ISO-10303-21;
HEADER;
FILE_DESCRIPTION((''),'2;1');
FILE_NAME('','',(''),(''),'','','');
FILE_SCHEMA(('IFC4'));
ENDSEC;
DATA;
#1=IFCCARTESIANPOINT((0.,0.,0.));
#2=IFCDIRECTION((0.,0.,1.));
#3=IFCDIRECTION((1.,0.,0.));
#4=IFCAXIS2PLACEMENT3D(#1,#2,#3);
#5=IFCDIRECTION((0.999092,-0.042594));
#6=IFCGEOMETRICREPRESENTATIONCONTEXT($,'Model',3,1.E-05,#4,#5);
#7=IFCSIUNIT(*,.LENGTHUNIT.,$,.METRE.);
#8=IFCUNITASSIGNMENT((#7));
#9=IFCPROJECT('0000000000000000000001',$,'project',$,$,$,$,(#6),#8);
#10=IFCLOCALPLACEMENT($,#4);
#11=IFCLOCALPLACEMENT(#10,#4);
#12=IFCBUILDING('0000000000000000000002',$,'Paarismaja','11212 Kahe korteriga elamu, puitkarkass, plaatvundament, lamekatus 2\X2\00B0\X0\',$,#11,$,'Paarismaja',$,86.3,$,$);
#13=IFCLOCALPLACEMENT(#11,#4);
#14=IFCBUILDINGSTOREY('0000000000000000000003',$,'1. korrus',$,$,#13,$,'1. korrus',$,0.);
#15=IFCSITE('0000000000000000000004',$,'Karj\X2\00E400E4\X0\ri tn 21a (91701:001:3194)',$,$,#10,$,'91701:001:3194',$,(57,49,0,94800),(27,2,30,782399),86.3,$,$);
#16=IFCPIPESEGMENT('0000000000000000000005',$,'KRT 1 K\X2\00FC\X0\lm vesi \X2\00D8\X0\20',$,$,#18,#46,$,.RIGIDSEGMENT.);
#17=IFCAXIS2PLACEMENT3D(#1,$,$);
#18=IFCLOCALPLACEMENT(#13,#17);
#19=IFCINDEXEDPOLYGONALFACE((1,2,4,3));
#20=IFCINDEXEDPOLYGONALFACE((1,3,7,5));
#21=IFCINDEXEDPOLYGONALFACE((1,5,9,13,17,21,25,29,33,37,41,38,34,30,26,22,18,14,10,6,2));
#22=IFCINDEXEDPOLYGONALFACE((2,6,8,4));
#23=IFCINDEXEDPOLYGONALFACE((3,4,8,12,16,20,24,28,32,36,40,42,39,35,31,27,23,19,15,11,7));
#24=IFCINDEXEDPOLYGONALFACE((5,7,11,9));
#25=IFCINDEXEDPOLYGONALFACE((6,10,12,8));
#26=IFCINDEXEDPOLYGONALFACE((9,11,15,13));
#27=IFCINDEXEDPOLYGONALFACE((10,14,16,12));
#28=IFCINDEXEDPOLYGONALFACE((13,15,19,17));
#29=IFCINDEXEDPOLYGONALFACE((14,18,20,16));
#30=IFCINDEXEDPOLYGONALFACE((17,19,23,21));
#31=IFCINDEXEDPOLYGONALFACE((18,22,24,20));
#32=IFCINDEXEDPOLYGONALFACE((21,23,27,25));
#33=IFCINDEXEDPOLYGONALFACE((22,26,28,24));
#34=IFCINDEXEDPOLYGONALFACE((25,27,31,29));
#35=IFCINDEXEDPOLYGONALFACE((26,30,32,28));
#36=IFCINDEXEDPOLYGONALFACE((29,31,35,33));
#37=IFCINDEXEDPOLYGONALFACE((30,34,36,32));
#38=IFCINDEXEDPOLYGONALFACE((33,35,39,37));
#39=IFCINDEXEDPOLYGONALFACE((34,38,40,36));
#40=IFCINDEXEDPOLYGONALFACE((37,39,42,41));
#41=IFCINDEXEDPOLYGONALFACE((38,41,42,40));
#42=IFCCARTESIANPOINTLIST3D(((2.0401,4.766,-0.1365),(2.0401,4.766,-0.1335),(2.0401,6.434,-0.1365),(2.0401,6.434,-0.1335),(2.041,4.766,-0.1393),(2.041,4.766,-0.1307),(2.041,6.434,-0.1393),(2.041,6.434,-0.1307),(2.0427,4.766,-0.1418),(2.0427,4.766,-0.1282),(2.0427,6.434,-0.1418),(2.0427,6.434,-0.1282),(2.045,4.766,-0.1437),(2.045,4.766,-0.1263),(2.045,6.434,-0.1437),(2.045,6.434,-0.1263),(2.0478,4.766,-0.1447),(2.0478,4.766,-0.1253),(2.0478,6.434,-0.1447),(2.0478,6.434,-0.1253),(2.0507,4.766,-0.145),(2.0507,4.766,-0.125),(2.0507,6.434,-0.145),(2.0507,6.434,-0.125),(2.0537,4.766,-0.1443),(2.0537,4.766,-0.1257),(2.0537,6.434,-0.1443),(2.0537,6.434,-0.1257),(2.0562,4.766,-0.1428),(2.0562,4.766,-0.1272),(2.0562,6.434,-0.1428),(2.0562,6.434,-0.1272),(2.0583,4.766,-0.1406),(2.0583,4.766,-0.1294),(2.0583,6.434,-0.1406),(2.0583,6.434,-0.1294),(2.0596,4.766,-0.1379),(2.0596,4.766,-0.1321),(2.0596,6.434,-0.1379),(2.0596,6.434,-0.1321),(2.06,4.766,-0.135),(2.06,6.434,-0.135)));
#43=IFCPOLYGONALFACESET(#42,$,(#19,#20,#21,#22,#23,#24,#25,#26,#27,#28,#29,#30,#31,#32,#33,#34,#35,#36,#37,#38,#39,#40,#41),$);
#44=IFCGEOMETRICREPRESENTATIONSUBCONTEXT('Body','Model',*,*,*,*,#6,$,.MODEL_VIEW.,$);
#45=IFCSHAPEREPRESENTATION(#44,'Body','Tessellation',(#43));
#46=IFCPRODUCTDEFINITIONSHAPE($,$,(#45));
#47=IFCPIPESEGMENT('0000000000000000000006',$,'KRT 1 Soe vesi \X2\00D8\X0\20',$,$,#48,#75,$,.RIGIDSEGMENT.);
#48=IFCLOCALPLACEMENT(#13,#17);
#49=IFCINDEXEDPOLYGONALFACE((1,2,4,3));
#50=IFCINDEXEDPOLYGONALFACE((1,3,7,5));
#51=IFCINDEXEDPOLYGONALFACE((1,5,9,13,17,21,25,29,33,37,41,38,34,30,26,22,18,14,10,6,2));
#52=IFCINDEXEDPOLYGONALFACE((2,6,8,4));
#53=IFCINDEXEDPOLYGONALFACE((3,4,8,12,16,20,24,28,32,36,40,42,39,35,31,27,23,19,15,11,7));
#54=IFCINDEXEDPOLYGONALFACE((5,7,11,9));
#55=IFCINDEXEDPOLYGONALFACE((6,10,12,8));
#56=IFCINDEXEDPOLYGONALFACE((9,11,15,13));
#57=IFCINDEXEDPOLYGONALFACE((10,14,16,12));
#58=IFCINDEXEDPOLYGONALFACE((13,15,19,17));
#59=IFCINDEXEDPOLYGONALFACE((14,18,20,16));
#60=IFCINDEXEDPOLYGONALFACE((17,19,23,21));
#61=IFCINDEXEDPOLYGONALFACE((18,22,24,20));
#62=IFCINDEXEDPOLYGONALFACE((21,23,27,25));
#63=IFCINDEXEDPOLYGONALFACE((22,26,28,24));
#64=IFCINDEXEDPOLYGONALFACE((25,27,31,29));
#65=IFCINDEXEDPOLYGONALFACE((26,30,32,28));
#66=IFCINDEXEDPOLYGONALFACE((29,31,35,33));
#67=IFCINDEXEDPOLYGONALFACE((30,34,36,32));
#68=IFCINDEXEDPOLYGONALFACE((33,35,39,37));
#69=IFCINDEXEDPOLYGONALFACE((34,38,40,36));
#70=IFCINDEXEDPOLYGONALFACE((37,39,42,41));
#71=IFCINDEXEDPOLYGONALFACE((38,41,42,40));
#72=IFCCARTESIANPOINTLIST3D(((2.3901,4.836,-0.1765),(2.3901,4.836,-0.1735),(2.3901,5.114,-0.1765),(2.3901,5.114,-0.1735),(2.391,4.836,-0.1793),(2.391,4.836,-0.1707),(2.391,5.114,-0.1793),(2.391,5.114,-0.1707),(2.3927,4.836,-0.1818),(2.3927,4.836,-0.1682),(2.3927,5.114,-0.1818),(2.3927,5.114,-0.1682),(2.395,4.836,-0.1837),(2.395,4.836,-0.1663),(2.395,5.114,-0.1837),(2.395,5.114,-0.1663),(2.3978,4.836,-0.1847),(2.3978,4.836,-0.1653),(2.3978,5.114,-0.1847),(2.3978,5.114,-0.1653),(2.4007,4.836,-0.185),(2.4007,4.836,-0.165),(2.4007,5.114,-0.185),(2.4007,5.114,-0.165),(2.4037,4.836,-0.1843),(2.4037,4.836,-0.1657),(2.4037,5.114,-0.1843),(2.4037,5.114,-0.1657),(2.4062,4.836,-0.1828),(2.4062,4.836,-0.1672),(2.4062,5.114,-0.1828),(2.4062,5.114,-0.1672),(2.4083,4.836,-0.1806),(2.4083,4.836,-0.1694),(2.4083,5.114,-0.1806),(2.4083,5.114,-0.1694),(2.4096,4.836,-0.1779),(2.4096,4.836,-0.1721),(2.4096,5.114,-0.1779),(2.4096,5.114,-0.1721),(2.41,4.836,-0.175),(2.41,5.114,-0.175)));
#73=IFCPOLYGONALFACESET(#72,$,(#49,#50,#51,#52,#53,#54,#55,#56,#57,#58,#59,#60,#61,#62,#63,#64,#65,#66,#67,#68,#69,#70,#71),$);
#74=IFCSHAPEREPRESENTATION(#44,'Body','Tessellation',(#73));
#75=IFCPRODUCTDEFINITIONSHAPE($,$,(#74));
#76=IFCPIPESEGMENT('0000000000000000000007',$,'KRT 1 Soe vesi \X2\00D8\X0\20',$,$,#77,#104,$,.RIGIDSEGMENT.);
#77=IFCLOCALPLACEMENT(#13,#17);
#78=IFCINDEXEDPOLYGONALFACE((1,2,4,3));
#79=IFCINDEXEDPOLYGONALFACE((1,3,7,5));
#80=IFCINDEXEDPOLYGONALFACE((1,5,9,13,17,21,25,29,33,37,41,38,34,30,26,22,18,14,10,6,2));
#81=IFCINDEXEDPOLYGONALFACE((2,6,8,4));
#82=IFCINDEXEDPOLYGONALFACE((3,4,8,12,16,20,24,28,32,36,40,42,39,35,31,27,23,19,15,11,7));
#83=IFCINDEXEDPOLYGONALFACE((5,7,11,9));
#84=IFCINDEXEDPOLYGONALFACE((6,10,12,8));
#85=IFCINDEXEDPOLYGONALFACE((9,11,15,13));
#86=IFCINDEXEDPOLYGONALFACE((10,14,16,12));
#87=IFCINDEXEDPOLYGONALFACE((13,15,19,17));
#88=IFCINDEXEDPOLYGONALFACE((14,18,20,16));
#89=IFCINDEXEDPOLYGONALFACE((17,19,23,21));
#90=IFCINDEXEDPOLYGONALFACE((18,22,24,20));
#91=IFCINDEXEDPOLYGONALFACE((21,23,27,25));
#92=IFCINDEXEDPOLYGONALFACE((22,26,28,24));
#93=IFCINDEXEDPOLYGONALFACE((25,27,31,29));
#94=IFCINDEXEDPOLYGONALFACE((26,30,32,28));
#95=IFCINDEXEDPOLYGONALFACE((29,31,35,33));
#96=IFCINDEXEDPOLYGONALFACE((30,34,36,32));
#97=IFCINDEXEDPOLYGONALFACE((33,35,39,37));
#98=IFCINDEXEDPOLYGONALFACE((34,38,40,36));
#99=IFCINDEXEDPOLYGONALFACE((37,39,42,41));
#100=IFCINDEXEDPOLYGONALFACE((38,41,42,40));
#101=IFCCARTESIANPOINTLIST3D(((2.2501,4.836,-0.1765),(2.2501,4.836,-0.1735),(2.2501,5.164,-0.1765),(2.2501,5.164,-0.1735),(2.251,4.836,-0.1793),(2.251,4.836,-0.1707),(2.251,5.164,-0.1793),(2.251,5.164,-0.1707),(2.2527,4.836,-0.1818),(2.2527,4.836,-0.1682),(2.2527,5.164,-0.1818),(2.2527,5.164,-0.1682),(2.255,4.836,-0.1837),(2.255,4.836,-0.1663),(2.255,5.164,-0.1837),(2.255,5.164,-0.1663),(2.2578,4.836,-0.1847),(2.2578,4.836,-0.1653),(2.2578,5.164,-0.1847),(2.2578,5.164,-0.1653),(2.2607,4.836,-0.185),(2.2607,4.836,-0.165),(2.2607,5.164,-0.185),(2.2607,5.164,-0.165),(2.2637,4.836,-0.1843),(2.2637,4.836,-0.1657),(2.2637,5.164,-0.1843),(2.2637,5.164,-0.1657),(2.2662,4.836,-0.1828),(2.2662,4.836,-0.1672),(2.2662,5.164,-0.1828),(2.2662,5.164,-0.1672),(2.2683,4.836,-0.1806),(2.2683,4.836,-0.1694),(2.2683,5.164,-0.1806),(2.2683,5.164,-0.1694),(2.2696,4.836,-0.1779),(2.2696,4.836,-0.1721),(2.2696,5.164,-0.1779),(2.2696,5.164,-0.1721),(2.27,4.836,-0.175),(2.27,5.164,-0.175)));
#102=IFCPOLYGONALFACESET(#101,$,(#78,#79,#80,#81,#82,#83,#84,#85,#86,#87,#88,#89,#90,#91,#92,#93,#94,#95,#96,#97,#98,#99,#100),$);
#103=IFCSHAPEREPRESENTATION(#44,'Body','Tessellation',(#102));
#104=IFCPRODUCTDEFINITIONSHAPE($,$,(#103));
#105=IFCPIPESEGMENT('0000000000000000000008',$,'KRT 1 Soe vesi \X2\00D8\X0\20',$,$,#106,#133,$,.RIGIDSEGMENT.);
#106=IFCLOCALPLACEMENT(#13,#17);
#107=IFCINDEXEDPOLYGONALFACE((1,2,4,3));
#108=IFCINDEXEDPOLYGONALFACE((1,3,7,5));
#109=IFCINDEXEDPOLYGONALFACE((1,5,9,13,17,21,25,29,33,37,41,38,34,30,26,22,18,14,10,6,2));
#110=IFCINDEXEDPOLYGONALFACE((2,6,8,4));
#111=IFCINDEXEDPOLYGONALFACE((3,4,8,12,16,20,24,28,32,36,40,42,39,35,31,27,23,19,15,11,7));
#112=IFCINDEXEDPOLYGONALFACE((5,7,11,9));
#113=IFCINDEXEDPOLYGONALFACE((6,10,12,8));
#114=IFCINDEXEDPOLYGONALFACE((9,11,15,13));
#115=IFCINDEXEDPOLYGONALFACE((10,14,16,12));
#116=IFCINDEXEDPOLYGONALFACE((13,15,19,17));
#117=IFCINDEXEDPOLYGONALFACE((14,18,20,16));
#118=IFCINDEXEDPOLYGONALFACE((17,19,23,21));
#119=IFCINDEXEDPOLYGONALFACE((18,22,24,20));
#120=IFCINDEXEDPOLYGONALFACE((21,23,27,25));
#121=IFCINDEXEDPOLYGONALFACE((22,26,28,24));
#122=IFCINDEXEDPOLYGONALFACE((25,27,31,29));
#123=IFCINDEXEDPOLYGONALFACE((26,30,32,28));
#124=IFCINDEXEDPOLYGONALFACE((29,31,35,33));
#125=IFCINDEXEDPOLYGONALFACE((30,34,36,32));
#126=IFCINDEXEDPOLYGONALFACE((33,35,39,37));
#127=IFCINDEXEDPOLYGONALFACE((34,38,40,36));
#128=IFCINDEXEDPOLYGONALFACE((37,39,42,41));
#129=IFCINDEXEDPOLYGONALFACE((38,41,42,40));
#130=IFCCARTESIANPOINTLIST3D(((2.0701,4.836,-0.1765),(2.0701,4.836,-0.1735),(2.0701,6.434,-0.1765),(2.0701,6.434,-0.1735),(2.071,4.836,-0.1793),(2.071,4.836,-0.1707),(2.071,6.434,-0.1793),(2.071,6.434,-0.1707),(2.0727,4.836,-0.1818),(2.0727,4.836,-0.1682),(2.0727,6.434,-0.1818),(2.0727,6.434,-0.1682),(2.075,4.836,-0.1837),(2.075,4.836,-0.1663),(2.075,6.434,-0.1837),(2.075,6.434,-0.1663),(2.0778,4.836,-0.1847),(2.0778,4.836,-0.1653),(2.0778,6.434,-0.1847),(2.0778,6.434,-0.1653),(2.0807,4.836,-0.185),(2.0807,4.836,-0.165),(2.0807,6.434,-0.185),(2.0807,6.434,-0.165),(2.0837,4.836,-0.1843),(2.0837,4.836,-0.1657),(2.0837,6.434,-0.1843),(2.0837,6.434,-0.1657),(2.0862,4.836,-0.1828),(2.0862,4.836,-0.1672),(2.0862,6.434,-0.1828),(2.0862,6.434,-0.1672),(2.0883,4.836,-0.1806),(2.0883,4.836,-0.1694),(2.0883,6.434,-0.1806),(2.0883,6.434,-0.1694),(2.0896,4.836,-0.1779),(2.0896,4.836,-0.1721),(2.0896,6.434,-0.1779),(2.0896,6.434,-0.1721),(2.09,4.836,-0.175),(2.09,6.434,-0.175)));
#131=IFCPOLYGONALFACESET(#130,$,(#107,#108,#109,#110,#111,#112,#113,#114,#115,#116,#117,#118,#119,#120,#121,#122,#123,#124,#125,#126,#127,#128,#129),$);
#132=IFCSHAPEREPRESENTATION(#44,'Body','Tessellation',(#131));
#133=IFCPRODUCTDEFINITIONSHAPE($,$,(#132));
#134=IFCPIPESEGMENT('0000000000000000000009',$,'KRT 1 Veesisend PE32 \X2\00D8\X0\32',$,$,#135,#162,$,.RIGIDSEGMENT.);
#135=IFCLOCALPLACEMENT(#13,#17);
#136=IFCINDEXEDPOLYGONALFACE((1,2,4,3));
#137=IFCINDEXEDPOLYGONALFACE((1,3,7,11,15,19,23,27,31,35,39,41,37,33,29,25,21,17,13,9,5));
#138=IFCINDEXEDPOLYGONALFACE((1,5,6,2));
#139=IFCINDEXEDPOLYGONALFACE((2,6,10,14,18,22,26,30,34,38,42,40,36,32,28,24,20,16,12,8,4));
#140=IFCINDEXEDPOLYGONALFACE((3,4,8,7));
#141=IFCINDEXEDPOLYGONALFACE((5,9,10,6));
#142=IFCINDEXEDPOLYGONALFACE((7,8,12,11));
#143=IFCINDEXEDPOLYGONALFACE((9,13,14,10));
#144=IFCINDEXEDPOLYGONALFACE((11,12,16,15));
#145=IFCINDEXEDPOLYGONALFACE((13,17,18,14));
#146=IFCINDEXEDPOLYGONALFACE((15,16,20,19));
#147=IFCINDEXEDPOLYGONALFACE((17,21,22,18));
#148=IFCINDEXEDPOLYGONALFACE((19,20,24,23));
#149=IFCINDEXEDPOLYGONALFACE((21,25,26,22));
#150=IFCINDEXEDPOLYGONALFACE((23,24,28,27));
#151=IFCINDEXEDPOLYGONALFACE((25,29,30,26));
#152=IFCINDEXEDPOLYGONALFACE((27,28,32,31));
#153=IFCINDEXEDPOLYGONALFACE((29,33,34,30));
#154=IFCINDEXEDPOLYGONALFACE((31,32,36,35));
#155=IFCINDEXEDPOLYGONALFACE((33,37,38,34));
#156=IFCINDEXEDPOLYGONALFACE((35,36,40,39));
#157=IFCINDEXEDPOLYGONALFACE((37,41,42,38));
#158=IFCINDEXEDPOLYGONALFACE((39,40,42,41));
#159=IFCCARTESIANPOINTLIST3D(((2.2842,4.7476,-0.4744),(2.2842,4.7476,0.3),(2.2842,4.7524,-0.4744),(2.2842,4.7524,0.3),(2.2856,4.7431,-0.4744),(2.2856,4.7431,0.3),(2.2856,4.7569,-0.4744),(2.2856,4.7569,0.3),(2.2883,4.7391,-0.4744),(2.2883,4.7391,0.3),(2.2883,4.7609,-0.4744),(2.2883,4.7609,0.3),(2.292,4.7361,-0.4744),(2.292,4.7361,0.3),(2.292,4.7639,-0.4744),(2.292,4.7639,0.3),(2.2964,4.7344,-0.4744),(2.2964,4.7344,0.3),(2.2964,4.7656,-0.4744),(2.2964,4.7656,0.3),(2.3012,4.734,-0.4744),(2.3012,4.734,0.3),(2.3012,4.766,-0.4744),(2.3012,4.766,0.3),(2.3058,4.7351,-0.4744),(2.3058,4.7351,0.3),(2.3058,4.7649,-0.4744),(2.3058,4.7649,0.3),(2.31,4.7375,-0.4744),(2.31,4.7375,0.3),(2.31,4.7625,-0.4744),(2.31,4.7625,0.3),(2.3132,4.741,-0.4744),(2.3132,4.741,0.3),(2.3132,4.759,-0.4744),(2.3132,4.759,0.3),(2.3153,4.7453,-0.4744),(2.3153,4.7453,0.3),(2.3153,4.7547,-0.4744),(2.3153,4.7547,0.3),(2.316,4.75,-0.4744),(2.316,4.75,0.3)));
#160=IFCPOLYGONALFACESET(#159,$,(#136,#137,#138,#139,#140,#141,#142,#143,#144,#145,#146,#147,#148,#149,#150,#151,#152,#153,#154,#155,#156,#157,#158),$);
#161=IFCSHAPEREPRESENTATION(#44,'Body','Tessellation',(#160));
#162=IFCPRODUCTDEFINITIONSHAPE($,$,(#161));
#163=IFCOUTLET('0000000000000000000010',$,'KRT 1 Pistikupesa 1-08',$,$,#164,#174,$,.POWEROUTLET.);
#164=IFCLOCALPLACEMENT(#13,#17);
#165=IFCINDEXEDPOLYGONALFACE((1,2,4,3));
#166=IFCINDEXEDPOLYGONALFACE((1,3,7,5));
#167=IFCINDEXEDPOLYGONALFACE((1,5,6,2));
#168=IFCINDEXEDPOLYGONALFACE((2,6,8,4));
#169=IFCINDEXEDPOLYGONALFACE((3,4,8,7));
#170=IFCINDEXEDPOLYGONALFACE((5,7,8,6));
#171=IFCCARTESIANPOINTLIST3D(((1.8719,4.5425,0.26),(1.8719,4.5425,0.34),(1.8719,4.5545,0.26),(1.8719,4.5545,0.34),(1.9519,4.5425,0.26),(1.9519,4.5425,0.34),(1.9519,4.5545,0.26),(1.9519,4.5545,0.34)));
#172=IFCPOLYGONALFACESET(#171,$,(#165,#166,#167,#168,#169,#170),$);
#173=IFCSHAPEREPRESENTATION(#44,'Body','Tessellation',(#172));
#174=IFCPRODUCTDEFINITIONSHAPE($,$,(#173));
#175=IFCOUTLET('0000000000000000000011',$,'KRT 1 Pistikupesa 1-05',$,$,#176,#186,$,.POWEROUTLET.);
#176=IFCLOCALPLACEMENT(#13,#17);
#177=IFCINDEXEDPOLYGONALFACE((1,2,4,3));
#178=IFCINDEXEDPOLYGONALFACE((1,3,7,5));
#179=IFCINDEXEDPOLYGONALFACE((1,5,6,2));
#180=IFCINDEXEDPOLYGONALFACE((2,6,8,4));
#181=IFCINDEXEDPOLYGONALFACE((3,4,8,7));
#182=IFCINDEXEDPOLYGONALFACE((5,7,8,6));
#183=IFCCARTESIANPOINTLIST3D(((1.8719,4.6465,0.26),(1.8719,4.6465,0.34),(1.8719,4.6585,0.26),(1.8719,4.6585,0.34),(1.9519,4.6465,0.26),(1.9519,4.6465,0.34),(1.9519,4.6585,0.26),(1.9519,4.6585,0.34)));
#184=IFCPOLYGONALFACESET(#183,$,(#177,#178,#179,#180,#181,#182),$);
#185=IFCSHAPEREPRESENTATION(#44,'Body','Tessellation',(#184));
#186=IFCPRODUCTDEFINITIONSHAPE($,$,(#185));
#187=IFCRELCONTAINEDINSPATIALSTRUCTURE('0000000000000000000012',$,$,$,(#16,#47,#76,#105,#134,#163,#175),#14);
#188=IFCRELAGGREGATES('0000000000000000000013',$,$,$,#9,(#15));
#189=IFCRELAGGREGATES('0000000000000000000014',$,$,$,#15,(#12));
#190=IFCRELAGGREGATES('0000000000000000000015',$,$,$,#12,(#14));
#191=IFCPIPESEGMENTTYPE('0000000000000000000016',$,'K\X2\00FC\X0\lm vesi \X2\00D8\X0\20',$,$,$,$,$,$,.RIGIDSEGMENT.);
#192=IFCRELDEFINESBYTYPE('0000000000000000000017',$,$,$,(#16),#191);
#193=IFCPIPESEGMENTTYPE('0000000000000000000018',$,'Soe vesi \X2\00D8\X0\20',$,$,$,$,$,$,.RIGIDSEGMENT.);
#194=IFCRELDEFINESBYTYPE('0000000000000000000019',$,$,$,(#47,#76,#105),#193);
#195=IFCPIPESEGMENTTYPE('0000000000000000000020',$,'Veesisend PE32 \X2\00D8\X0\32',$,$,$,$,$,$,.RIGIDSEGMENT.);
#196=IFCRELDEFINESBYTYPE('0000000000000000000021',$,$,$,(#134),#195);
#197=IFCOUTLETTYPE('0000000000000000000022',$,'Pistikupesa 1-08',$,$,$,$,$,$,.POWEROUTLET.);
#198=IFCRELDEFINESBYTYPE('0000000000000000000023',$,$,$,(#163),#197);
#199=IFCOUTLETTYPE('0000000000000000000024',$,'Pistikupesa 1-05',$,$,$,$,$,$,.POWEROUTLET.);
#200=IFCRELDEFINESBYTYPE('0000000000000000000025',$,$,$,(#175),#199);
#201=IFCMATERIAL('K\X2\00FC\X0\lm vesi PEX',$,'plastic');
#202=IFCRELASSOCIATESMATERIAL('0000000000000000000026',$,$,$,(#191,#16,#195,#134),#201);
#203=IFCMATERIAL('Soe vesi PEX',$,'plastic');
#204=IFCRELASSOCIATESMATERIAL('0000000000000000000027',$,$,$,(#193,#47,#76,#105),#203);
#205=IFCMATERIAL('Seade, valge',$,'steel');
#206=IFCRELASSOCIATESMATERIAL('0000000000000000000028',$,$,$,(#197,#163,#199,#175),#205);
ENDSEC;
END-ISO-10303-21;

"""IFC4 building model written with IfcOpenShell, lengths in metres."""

from ifc_helpers import new_model, si_unit, direction, frame, origin_with_axes, place, context, subcontext, project, spatial, indexed_curve, circle, outline, extrude, material, type_object, element, save


model = new_model("IFC4")

# Units and contexts
model_context = context("Model", 3, precision=1e-05, world=origin_with_axes(), true_north=direction((0.999092, -0.042594)))
body_context = subcontext(model_context, "Body", "Model", "MODEL_VIEW")
ifc_project = project(units=[si_unit("LENGTHUNIT", "METRE")], contexts=[model_context])

# Site, building, storey
site_placement = place(None, origin_with_axes())
site = spatial("IfcSite", under=ifc_project, at=site_placement, Name="Karjääri tn 21a (91701:001:3194)", LongName="91701:001:3194", RefLatitude=(57, 49, 0, 94800), RefLongitude=(27, 2, 30, 782399), RefElevation=86.3)
building_placement = place(site_placement, origin_with_axes())
building = spatial("IfcBuilding", under=site, at=building_placement, Name="Paarismaja", Description="11212 Kahe korteriga elamu, puitkarkass, plaatvundament, lamekatus 2°", LongName="Paarismaja", ElevationOfRefHeight=86.3)
storey_placement = place(building_placement, origin_with_axes())
storey = spatial("IfcBuildingStorey", under=building, at=storey_placement, Name="1. korrus", LongName="1. korrus", Elevation=0.0)

# Shared definitions
ifc_material_1 = material(Name="Seade, valge", Category="steel")

# Shared definitions
ifc_material_2 = material(Name="Külm vesi PEX", Category="plastic")
ifc_material_3 = material(Name="Soe vesi PEX", Category="plastic")

# Pipe segments
pipe_segment_type_1 = type_object("IfcPipeSegmentType", Name="Külm vesi Ø20", PredefinedType="RIGIDSEGMENT", material=ifc_material_2)
pipe_segment_1_placement = place(storey_placement, frame((2.05, 4.766, -0.135), z_axis=(0.0, 1.0, 0.0), x_axis=(1.0, 0.0, 0.0)))
element("IfcPipeSegment", 1, at=pipe_segment_1_placement, inside=storey, type_object=pipe_segment_type_1, material=ifc_material_2, Name="KRT 1 Külm vesi Ø20", PredefinedType="RIGIDSEGMENT", context=body_context, shape_type="SweptSolid", body=[
    extrude(circle(Radius=0.01), origin_with_axes(), (0.0, 0.0, 1.0), 1.668),
])
pipe_segment_type_2 = type_object("IfcPipeSegmentType", Name="Soe vesi Ø20", PredefinedType="RIGIDSEGMENT", material=ifc_material_3)
pipe_segment_2_placement = place(storey_placement, frame((2.4, 4.836, -0.175), z_axis=(0.0, 1.0, 0.0), x_axis=(1.0, 0.0, 0.0)))
element("IfcPipeSegment", 2, at=pipe_segment_2_placement, inside=storey, type_object=pipe_segment_type_2, material=ifc_material_3, Name="KRT 1 Soe vesi Ø20", PredefinedType="RIGIDSEGMENT", context=body_context, shape_type="SweptSolid", body=[
    extrude(circle(Radius=0.01), origin_with_axes(), (0.0, 0.0, 1.0), 0.278),
])
pipe_segment_3_placement = place(storey_placement, frame((2.26, 4.836, -0.175), z_axis=(0.0, 1.0, 0.0), x_axis=(1.0, 0.0, 0.0)))
element("IfcPipeSegment", 3, at=pipe_segment_3_placement, inside=storey, type_object=pipe_segment_type_2, material=ifc_material_3, Name="KRT 1 Soe vesi Ø20", PredefinedType="RIGIDSEGMENT", context=body_context, shape_type="SweptSolid", body=[
    extrude(circle(Radius=0.01), origin_with_axes(), (0.0, 0.0, 1.0), 0.328),
])
pipe_segment_4_placement = place(storey_placement, frame((2.08, 4.836, -0.175), z_axis=(0.0, 1.0, 0.0), x_axis=(1.0, 0.0, 0.0)))
element("IfcPipeSegment", 4, at=pipe_segment_4_placement, inside=storey, type_object=pipe_segment_type_2, material=ifc_material_3, Name="KRT 1 Soe vesi Ø20", PredefinedType="RIGIDSEGMENT", context=body_context, shape_type="SweptSolid", body=[
    extrude(circle(Radius=0.01), origin_with_axes(), (0.0, 0.0, 1.0), 1.598),
])
pipe_segment_type_3 = type_object("IfcPipeSegmentType", Name="Veesisend PE32 Ø32", PredefinedType="RIGIDSEGMENT", material=ifc_material_2)
pipe_segment_5_placement = place(storey_placement, frame((2.3, 4.75, -0.4744), z_axis=(0.0, 0.0, 1.0), x_axis=(1.0, 0.0, 0.0)))
element("IfcPipeSegment", 5, at=pipe_segment_5_placement, inside=storey, type_object=pipe_segment_type_3, material=ifc_material_2, Name="KRT 1 Veesisend PE32 Ø32", PredefinedType="RIGIDSEGMENT", context=body_context, shape_type="SweptSolid", body=[
    extrude(circle(Radius=0.016), origin_with_axes(), (0.0, 0.0, 1.0), 0.7744),
])

# Outlets
outlet_type_1 = type_object("IfcOutletType", Name="Pistikupesa 1-08", PredefinedType="POWEROUTLET", material=ifc_material_1)
outlet_1_placement = place(storey_placement, frame((1.9119, 4.5485, 0.0), z_axis=(0.0, 0.0, 1.0), x_axis=(-1.0, 0.0, 0.0)))
element("IfcOutlet", 6, at=outlet_1_placement, inside=storey, type_object=outlet_type_1, material=ifc_material_1, Name="KRT 1 Pistikupesa 1-08", PredefinedType="POWEROUTLET", context=body_context, shape_type="SweptSolid", body=[
    extrude(outline(indexed_curve([(-0.04, -0.006), (0.04, -0.006), (0.04, 0.006), (-0.04, 0.006), (-0.04, -0.006)], self_intersect=False)), frame((0.0, 0.0, 0.26), z_axis=(0.0, 0.0, 1.0), x_axis=(1.0, 0.0, 0.0)), (0.0, 0.0, 1.0), 0.08),
])
outlet_type_2 = type_object("IfcOutletType", Name="Pistikupesa 1-05", PredefinedType="POWEROUTLET", material=ifc_material_1)
outlet_2_placement = place(storey_placement, frame((1.9119, 4.6525, 0.0), z_axis=(0.0, 0.0, 1.0), x_axis=(1.0, 0.0, 0.0)))
element("IfcOutlet", 7, at=outlet_2_placement, inside=storey, type_object=outlet_type_2, material=ifc_material_1, Name="KRT 1 Pistikupesa 1-05", PredefinedType="POWEROUTLET", context=body_context, shape_type="SweptSolid", body=[
    extrude(outline(indexed_curve([(-0.04, -0.006), (0.04, -0.006), (0.04, 0.006), (-0.04, 0.006), (-0.04, -0.006)], self_intersect=False)), frame((0.0, 0.0, 0.26), z_axis=(0.0, 0.0, 1.0), x_axis=(1.0, 0.0, 0.0)), (0.0, 0.0, 1.0), 0.08),
])

save(model, "model.ifc")
